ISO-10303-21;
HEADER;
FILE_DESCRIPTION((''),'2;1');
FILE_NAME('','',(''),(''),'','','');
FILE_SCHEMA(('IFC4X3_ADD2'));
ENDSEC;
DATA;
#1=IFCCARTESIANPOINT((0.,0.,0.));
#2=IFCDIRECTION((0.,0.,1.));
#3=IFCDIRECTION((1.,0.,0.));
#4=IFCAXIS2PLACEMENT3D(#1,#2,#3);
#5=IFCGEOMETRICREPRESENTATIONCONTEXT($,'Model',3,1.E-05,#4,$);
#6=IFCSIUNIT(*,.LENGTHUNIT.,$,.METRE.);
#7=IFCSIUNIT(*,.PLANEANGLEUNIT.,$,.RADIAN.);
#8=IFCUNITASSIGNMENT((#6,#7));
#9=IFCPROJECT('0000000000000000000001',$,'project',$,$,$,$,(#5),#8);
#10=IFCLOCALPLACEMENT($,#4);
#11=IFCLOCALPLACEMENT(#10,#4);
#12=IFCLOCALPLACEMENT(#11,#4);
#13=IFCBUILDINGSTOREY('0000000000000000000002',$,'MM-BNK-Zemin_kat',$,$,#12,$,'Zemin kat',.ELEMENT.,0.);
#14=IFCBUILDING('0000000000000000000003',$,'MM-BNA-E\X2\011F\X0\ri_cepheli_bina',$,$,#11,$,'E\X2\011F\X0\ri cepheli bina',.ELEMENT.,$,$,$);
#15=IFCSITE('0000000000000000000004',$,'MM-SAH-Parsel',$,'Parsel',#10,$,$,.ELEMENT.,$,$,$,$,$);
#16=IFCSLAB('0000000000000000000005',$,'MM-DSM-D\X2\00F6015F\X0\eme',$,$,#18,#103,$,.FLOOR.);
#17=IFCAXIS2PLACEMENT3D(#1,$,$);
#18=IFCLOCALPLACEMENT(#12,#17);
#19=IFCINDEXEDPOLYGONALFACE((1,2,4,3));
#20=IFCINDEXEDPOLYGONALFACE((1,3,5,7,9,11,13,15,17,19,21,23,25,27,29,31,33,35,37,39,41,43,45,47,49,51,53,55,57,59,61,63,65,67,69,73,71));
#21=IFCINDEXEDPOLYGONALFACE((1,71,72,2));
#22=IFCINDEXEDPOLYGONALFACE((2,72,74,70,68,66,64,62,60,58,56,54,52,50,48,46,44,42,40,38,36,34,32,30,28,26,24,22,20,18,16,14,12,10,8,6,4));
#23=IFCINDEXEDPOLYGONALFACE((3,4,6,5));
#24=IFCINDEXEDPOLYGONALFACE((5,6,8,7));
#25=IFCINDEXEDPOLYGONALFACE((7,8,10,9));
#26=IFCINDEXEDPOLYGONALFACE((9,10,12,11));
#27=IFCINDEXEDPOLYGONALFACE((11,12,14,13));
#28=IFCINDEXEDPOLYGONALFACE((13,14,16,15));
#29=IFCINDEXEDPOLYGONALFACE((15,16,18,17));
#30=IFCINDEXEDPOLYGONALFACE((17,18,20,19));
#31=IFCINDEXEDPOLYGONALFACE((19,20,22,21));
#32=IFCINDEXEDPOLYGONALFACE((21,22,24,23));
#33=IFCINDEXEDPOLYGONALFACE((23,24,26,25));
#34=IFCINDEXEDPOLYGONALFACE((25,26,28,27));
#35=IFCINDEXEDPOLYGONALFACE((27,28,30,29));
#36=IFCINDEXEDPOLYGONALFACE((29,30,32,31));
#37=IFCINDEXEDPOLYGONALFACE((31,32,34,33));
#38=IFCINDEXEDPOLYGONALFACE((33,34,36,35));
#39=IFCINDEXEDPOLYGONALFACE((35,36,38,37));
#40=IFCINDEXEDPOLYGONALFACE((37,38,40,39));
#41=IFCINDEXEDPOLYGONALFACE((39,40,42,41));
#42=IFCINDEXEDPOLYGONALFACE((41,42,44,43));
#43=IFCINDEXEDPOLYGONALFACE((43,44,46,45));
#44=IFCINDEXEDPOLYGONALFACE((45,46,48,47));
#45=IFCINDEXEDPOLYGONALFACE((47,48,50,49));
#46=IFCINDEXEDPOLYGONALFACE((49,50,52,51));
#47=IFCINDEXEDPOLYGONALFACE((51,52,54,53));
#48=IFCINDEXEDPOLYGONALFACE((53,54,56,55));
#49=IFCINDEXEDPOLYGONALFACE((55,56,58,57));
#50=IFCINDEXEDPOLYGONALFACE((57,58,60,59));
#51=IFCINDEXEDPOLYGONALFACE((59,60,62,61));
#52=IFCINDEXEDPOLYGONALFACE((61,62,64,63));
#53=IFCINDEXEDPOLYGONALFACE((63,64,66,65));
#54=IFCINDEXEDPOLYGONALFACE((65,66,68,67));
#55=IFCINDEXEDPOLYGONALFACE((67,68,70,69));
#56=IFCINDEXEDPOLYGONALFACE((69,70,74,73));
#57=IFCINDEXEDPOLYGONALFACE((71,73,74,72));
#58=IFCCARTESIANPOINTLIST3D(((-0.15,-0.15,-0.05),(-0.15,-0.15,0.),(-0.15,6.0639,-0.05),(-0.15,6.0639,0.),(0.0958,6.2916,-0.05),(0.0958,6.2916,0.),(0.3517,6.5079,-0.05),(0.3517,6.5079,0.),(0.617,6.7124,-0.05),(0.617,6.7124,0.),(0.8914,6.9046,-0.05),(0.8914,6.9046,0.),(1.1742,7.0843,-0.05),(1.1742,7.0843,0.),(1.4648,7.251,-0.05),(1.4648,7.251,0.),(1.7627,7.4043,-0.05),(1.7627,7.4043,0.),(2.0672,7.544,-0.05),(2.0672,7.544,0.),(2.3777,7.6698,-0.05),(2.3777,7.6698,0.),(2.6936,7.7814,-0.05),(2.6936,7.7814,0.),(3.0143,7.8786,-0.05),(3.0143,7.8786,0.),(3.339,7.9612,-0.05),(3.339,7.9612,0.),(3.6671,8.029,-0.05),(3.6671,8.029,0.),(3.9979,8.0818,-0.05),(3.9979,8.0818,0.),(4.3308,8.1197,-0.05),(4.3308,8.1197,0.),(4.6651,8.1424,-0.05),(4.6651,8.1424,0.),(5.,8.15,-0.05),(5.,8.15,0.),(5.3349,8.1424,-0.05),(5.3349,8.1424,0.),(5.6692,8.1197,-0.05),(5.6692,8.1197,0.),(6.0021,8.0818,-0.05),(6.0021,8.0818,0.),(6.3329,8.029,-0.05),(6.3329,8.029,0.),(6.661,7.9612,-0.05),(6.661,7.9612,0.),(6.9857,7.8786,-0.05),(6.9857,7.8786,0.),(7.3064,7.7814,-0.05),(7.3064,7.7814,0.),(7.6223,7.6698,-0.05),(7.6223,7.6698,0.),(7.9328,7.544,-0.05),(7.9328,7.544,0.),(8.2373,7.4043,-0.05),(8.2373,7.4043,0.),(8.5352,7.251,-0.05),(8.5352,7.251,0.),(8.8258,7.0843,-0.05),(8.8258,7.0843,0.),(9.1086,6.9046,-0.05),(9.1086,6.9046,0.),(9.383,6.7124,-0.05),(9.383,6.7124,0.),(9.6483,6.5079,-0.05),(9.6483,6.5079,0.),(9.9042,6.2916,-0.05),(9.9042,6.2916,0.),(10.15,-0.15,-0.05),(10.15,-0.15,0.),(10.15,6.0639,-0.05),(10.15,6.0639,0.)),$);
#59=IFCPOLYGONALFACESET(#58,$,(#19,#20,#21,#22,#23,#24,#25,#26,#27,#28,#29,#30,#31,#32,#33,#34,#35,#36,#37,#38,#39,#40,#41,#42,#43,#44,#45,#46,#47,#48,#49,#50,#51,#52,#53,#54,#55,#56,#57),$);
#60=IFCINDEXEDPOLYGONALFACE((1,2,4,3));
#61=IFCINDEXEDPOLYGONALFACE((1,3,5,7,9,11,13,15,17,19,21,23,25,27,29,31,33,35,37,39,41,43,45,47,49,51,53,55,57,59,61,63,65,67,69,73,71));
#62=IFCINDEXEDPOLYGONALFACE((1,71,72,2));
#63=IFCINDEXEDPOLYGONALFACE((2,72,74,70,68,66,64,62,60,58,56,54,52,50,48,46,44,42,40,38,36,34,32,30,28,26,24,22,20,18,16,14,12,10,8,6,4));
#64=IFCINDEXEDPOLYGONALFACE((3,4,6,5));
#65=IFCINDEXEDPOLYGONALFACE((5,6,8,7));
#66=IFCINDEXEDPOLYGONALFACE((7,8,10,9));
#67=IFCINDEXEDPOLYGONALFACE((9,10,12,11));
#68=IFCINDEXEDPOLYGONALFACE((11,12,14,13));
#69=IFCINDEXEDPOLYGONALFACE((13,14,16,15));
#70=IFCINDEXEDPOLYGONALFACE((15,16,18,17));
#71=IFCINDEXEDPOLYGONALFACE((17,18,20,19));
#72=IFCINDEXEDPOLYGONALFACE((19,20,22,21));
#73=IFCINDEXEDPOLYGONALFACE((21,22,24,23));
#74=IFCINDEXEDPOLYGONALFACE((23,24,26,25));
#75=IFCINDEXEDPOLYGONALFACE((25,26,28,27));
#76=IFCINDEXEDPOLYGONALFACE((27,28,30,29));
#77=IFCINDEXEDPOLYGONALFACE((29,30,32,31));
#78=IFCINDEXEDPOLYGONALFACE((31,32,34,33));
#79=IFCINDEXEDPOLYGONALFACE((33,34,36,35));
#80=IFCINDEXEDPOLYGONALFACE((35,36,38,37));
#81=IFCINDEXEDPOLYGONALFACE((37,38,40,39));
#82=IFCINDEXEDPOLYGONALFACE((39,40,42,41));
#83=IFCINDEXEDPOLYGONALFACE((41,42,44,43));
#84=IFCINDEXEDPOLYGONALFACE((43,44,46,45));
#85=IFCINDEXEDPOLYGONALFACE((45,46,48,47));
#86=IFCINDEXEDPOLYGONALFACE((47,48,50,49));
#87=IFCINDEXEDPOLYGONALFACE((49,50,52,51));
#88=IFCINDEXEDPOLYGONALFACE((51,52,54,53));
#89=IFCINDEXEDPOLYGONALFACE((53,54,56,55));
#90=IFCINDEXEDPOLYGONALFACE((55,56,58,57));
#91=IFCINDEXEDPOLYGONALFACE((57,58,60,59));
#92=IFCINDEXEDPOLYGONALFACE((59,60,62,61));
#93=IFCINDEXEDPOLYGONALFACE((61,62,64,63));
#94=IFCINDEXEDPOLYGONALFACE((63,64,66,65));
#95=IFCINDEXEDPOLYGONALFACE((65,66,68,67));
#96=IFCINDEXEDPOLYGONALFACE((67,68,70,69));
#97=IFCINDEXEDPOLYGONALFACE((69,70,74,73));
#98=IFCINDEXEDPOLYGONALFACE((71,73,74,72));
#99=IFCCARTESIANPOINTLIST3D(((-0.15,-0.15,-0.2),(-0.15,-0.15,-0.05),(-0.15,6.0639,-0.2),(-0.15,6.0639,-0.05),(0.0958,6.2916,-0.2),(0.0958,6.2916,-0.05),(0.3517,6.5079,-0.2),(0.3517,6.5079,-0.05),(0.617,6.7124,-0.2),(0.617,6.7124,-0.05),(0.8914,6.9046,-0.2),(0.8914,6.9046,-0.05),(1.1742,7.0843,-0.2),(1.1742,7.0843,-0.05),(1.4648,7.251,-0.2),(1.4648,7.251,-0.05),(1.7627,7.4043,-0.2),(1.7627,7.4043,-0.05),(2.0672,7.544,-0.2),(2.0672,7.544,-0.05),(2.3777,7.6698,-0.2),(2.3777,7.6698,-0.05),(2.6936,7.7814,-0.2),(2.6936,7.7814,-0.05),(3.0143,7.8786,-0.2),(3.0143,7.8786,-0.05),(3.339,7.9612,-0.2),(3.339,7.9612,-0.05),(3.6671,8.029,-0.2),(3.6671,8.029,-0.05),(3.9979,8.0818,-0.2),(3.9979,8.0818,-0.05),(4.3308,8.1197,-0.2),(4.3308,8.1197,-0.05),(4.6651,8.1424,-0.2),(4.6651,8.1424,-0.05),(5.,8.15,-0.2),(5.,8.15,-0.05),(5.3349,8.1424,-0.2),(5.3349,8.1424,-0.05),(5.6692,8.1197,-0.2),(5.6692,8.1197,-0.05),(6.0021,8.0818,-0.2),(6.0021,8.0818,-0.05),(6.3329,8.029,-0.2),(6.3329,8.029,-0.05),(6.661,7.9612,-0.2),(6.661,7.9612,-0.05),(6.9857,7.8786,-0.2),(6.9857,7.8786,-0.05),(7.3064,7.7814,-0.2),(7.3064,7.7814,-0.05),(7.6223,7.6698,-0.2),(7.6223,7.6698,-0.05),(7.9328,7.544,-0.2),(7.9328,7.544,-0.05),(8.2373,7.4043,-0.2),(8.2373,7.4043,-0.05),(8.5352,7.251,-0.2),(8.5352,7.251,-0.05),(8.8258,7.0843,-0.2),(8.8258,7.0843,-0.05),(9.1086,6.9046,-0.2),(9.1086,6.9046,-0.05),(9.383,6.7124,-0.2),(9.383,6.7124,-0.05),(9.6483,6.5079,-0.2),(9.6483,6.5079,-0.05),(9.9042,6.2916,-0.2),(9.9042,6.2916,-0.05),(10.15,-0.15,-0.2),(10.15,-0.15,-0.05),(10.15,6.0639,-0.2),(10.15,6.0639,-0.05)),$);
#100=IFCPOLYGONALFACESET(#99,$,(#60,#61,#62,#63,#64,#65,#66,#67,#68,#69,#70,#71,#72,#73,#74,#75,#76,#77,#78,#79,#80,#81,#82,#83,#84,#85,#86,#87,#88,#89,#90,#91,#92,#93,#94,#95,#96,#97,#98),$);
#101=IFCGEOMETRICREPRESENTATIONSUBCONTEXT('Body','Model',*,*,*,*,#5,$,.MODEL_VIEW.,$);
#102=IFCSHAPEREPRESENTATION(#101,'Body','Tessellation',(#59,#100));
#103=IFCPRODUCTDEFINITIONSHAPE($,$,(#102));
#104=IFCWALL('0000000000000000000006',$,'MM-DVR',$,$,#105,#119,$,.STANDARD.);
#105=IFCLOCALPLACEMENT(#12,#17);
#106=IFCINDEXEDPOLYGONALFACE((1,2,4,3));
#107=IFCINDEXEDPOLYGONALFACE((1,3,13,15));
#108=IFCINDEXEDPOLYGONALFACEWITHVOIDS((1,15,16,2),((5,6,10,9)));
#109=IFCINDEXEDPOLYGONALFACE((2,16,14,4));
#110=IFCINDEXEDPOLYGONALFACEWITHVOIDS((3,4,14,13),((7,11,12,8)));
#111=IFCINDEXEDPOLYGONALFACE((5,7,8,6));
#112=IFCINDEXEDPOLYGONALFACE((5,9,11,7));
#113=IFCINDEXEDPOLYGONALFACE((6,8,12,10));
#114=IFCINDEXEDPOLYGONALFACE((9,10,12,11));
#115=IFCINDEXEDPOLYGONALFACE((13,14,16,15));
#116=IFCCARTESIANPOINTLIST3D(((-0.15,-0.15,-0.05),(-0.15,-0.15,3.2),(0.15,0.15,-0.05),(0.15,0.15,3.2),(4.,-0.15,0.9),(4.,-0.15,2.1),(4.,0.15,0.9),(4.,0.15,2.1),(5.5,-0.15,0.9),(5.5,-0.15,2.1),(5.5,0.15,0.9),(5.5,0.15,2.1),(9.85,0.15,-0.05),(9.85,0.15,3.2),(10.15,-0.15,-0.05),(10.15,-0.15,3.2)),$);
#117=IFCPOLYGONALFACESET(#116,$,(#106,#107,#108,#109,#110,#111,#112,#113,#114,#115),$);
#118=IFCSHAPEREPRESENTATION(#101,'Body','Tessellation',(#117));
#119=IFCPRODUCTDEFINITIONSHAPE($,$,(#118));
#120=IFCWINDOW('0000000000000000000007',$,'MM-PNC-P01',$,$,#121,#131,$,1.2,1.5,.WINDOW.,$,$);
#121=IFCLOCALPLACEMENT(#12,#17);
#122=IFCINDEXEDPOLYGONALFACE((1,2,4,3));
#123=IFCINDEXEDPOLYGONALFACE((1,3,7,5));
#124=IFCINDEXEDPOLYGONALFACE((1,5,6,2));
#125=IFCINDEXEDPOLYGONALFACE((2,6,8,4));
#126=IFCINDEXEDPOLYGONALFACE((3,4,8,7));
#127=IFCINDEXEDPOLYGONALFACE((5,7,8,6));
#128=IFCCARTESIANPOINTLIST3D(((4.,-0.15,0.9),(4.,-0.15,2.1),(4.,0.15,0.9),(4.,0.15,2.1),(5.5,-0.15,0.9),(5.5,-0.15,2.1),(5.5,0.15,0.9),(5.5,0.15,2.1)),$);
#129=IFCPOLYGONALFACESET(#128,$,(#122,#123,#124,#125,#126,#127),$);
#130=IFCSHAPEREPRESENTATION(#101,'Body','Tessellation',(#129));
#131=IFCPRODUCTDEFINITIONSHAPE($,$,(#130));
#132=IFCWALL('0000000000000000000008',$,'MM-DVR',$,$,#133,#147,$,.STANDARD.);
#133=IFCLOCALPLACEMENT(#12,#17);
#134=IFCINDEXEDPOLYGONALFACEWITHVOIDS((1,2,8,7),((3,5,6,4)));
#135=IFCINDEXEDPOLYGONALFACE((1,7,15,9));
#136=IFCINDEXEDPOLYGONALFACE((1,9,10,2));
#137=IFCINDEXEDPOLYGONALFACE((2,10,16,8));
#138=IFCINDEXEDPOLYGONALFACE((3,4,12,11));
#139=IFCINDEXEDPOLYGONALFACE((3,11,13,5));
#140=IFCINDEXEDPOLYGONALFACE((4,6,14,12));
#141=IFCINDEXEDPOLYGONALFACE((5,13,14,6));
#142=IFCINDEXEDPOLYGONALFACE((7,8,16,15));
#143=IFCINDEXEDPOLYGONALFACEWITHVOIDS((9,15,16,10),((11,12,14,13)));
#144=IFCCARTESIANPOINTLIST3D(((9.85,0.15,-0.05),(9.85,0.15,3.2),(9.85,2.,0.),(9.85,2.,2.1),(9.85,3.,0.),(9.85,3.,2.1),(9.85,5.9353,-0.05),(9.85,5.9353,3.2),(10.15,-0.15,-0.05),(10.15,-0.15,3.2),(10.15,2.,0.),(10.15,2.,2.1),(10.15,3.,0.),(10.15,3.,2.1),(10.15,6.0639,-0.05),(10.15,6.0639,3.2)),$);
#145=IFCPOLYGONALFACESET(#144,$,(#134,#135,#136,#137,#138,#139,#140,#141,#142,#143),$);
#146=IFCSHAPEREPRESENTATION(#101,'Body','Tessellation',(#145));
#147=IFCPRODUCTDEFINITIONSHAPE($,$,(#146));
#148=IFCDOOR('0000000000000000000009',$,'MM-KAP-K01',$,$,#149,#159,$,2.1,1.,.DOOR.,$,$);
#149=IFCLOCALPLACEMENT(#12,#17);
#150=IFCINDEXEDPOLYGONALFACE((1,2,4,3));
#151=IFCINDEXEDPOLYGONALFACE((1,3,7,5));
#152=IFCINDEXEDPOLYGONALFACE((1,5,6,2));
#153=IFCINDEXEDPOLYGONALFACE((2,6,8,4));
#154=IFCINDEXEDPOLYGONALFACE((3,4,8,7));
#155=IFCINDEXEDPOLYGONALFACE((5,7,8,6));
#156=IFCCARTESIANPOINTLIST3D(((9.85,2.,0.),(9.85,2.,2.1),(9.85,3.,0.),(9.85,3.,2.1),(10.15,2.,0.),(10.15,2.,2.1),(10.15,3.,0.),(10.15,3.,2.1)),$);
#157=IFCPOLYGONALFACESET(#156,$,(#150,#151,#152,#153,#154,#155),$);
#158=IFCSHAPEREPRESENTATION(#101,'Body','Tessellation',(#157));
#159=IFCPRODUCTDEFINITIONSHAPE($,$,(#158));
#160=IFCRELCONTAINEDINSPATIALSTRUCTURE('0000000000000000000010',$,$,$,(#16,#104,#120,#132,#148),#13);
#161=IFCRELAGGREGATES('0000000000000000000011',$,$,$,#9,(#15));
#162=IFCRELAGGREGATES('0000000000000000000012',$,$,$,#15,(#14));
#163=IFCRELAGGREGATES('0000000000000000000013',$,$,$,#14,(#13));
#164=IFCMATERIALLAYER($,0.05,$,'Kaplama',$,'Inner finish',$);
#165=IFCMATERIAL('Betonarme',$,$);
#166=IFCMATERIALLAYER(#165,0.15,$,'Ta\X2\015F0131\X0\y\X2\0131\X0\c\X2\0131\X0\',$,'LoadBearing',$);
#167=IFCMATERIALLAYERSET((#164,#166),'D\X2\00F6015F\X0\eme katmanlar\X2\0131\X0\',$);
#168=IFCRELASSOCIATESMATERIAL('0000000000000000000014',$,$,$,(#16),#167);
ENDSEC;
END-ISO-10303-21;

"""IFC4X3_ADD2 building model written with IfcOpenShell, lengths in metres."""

from ifc_helpers import new_model, si_unit, frame, origin, origin_with_axes, place, context, subcontext, project, spatial, polyline, line, arc, indexed_curve, outline, extrude, material, layer, layer_set, layer_usage, element, fill, save


model = new_model("IFC4X3_ADD2")

# Units and contexts
model_context = context("Model", 3, precision=1e-05, world=origin_with_axes())
body_context = subcontext(model_context, "Body", "Model", "MODEL_VIEW")
ifc_project = project(units=[si_unit("LENGTHUNIT", "METRE"), si_unit("PLANEANGLEUNIT", "RADIAN")], contexts=[model_context])

# Site, building, storey
site_placement = place(None, origin_with_axes())
site = spatial("IfcSite", under=ifc_project, at=site_placement, Name="MM-SAH-Parsel", ObjectType="Parsel", CompositionType="ELEMENT")
building_placement = place(site_placement, origin_with_axes())
building = spatial("IfcBuilding", under=site, at=building_placement, Name="MM-BNA-Eğri_cepheli_bina", LongName="Eğri cepheli bina", CompositionType="ELEMENT")
storey_placement = place(building_placement, origin_with_axes())
storey = spatial("IfcBuildingStorey", under=building, at=storey_placement, Name="MM-BNK-Zemin_kat", LongName="Zemin kat", CompositionType="ELEMENT", Elevation=0.0)

# Slab
ifc_layer_1 = layer(None, 0.05, Name="Kaplama", Category="Inner finish")
ifc_material = material(Name="Betonarme")
ifc_layer_2 = layer(ifc_material, 0.15, Name="Taşıyıcı", Category="LoadBearing")
ifc_layer_set = layer_set([ifc_layer_1, ifc_layer_2], Name="Döşeme katmanları")
ifc_layer_usage = layer_usage(ifc_layer_set, "AXIS3", "NEGATIVE", 0.0)
slab_placement = place(storey_placement, origin_with_axes())
element("IfcSlab", 1, at=slab_placement, inside=storey, material=ifc_layer_usage, Name="MM-DSM-Döşeme", PredefinedType="FLOOR", context=body_context, shape_type="SweptSolid", body=[
    extrude(outline(indexed_curve([(-0.15, -0.15), (10.15, -0.15), (10.15, 6.0639), (5.0, 8.15), (-0.15, 6.0639)], segments=[line(1, 2, 3), arc(3, 4, 5), line(5, 1)], self_intersect=False)), frame((0.0, 0.0, -0.05)), (0.0, 0.0, 1.0), 0.05),
    extrude(outline(indexed_curve([(-0.15, -0.15), (10.15, -0.15), (10.15, 6.0639), (5.0, 8.15), (-0.15, 6.0639)], segments=[line(1, 2, 3), arc(3, 4, 5), line(5, 1)], self_intersect=False)), frame((0.0, 0.0, -0.2)), (0.0, 0.0, 1.0), 0.15),
])

# Wall, opening, window
wall_1_placement = place(storey_placement, origin_with_axes())
wall_1 = element("IfcWall", 2, at=wall_1_placement, inside=storey, Name="MM-DVR", PredefinedType="STANDARD", context=body_context, shape_type="SweptSolid", body=[
    extrude(outline(polyline([(0.15, 0.15), (9.85, 0.15), (10.15, -0.15), (-0.15, -0.15), (0.15, 0.15)])), frame((0.0, 0.0, -0.05)), (0.0, 0.0, 1.0), 3.25),
])
opening_1_placement = place(storey_placement, origin_with_axes())
opening_1 = element("IfcOpeningElement", 3, at=opening_1_placement, cuts=wall_1, PredefinedType="OPENING", context=body_context, shape_type="SweptSolid", body=[
    extrude(outline(polyline([(4.0, 0.15), (5.5, 0.15), (5.5, -0.15), (4.0, -0.15), (4.0, 0.15)])), frame((0.0, 0.0, 0.9)), (0.0, 0.0, 1.0), 1.2),
])
window_1_placement = place(storey_placement, origin_with_axes())
window_1 = element("IfcWindow", 4, at=window_1_placement, inside=storey, Name="MM-PNC-P01", OverallHeight=1.2, OverallWidth=1.5, PredefinedType="WINDOW", context=body_context, shape_type="SweptSolid", body=[
    extrude(outline(polyline([(4.0, 0.15), (5.5, 0.15), (5.5, -0.15), (4.0, -0.15), (4.0, 0.15)])), frame((0.0, 0.0, 0.9)), (0.0, 0.0, 1.0), 1.2),
])
fill(opening_1, window_1)

# Wall, opening, door
wall_2_placement = place(storey_placement, origin_with_axes())
wall_2 = element("IfcWall", 5, at=wall_2_placement, inside=storey, Name="MM-DVR", PredefinedType="STANDARD", context=body_context, shape_type="SweptSolid", body=[
    extrude(outline(polyline([(9.85, 0.15), (9.85, 5.9353), (10.15, 6.0639), (10.15, -0.15), (9.85, 0.15)])), frame((0.0, 0.0, -0.05)), (0.0, 0.0, 1.0), 3.25),
])
opening_2_placement = place(storey_placement, origin_with_axes())
opening_2 = element("IfcOpeningElement", 6, at=opening_2_placement, cuts=wall_2, PredefinedType="OPENING", context=body_context, shape_type="SweptSolid", body=[
    extrude(outline(polyline([(9.85, 2.0), (9.85, 3.0), (10.15, 3.0), (10.15, 2.0), (9.85, 2.0)])), origin(), (0.0, 0.0, 1.0), 2.1),
])
door_placement = place(storey_placement, origin_with_axes())
door = element("IfcDoor", 7, at=door_placement, inside=storey, Name="MM-KAP-K01", OverallHeight=2.1, OverallWidth=1.0, PredefinedType="DOOR", context=body_context, shape_type="SweptSolid", body=[
    extrude(outline(polyline([(9.85, 2.0), (9.85, 3.0), (10.15, 3.0), (10.15, 2.0), (9.85, 2.0)])), origin(), (0.0, 0.0, 1.0), 2.1),
])
fill(opening_2, door)

save(model, "model.ifc")
